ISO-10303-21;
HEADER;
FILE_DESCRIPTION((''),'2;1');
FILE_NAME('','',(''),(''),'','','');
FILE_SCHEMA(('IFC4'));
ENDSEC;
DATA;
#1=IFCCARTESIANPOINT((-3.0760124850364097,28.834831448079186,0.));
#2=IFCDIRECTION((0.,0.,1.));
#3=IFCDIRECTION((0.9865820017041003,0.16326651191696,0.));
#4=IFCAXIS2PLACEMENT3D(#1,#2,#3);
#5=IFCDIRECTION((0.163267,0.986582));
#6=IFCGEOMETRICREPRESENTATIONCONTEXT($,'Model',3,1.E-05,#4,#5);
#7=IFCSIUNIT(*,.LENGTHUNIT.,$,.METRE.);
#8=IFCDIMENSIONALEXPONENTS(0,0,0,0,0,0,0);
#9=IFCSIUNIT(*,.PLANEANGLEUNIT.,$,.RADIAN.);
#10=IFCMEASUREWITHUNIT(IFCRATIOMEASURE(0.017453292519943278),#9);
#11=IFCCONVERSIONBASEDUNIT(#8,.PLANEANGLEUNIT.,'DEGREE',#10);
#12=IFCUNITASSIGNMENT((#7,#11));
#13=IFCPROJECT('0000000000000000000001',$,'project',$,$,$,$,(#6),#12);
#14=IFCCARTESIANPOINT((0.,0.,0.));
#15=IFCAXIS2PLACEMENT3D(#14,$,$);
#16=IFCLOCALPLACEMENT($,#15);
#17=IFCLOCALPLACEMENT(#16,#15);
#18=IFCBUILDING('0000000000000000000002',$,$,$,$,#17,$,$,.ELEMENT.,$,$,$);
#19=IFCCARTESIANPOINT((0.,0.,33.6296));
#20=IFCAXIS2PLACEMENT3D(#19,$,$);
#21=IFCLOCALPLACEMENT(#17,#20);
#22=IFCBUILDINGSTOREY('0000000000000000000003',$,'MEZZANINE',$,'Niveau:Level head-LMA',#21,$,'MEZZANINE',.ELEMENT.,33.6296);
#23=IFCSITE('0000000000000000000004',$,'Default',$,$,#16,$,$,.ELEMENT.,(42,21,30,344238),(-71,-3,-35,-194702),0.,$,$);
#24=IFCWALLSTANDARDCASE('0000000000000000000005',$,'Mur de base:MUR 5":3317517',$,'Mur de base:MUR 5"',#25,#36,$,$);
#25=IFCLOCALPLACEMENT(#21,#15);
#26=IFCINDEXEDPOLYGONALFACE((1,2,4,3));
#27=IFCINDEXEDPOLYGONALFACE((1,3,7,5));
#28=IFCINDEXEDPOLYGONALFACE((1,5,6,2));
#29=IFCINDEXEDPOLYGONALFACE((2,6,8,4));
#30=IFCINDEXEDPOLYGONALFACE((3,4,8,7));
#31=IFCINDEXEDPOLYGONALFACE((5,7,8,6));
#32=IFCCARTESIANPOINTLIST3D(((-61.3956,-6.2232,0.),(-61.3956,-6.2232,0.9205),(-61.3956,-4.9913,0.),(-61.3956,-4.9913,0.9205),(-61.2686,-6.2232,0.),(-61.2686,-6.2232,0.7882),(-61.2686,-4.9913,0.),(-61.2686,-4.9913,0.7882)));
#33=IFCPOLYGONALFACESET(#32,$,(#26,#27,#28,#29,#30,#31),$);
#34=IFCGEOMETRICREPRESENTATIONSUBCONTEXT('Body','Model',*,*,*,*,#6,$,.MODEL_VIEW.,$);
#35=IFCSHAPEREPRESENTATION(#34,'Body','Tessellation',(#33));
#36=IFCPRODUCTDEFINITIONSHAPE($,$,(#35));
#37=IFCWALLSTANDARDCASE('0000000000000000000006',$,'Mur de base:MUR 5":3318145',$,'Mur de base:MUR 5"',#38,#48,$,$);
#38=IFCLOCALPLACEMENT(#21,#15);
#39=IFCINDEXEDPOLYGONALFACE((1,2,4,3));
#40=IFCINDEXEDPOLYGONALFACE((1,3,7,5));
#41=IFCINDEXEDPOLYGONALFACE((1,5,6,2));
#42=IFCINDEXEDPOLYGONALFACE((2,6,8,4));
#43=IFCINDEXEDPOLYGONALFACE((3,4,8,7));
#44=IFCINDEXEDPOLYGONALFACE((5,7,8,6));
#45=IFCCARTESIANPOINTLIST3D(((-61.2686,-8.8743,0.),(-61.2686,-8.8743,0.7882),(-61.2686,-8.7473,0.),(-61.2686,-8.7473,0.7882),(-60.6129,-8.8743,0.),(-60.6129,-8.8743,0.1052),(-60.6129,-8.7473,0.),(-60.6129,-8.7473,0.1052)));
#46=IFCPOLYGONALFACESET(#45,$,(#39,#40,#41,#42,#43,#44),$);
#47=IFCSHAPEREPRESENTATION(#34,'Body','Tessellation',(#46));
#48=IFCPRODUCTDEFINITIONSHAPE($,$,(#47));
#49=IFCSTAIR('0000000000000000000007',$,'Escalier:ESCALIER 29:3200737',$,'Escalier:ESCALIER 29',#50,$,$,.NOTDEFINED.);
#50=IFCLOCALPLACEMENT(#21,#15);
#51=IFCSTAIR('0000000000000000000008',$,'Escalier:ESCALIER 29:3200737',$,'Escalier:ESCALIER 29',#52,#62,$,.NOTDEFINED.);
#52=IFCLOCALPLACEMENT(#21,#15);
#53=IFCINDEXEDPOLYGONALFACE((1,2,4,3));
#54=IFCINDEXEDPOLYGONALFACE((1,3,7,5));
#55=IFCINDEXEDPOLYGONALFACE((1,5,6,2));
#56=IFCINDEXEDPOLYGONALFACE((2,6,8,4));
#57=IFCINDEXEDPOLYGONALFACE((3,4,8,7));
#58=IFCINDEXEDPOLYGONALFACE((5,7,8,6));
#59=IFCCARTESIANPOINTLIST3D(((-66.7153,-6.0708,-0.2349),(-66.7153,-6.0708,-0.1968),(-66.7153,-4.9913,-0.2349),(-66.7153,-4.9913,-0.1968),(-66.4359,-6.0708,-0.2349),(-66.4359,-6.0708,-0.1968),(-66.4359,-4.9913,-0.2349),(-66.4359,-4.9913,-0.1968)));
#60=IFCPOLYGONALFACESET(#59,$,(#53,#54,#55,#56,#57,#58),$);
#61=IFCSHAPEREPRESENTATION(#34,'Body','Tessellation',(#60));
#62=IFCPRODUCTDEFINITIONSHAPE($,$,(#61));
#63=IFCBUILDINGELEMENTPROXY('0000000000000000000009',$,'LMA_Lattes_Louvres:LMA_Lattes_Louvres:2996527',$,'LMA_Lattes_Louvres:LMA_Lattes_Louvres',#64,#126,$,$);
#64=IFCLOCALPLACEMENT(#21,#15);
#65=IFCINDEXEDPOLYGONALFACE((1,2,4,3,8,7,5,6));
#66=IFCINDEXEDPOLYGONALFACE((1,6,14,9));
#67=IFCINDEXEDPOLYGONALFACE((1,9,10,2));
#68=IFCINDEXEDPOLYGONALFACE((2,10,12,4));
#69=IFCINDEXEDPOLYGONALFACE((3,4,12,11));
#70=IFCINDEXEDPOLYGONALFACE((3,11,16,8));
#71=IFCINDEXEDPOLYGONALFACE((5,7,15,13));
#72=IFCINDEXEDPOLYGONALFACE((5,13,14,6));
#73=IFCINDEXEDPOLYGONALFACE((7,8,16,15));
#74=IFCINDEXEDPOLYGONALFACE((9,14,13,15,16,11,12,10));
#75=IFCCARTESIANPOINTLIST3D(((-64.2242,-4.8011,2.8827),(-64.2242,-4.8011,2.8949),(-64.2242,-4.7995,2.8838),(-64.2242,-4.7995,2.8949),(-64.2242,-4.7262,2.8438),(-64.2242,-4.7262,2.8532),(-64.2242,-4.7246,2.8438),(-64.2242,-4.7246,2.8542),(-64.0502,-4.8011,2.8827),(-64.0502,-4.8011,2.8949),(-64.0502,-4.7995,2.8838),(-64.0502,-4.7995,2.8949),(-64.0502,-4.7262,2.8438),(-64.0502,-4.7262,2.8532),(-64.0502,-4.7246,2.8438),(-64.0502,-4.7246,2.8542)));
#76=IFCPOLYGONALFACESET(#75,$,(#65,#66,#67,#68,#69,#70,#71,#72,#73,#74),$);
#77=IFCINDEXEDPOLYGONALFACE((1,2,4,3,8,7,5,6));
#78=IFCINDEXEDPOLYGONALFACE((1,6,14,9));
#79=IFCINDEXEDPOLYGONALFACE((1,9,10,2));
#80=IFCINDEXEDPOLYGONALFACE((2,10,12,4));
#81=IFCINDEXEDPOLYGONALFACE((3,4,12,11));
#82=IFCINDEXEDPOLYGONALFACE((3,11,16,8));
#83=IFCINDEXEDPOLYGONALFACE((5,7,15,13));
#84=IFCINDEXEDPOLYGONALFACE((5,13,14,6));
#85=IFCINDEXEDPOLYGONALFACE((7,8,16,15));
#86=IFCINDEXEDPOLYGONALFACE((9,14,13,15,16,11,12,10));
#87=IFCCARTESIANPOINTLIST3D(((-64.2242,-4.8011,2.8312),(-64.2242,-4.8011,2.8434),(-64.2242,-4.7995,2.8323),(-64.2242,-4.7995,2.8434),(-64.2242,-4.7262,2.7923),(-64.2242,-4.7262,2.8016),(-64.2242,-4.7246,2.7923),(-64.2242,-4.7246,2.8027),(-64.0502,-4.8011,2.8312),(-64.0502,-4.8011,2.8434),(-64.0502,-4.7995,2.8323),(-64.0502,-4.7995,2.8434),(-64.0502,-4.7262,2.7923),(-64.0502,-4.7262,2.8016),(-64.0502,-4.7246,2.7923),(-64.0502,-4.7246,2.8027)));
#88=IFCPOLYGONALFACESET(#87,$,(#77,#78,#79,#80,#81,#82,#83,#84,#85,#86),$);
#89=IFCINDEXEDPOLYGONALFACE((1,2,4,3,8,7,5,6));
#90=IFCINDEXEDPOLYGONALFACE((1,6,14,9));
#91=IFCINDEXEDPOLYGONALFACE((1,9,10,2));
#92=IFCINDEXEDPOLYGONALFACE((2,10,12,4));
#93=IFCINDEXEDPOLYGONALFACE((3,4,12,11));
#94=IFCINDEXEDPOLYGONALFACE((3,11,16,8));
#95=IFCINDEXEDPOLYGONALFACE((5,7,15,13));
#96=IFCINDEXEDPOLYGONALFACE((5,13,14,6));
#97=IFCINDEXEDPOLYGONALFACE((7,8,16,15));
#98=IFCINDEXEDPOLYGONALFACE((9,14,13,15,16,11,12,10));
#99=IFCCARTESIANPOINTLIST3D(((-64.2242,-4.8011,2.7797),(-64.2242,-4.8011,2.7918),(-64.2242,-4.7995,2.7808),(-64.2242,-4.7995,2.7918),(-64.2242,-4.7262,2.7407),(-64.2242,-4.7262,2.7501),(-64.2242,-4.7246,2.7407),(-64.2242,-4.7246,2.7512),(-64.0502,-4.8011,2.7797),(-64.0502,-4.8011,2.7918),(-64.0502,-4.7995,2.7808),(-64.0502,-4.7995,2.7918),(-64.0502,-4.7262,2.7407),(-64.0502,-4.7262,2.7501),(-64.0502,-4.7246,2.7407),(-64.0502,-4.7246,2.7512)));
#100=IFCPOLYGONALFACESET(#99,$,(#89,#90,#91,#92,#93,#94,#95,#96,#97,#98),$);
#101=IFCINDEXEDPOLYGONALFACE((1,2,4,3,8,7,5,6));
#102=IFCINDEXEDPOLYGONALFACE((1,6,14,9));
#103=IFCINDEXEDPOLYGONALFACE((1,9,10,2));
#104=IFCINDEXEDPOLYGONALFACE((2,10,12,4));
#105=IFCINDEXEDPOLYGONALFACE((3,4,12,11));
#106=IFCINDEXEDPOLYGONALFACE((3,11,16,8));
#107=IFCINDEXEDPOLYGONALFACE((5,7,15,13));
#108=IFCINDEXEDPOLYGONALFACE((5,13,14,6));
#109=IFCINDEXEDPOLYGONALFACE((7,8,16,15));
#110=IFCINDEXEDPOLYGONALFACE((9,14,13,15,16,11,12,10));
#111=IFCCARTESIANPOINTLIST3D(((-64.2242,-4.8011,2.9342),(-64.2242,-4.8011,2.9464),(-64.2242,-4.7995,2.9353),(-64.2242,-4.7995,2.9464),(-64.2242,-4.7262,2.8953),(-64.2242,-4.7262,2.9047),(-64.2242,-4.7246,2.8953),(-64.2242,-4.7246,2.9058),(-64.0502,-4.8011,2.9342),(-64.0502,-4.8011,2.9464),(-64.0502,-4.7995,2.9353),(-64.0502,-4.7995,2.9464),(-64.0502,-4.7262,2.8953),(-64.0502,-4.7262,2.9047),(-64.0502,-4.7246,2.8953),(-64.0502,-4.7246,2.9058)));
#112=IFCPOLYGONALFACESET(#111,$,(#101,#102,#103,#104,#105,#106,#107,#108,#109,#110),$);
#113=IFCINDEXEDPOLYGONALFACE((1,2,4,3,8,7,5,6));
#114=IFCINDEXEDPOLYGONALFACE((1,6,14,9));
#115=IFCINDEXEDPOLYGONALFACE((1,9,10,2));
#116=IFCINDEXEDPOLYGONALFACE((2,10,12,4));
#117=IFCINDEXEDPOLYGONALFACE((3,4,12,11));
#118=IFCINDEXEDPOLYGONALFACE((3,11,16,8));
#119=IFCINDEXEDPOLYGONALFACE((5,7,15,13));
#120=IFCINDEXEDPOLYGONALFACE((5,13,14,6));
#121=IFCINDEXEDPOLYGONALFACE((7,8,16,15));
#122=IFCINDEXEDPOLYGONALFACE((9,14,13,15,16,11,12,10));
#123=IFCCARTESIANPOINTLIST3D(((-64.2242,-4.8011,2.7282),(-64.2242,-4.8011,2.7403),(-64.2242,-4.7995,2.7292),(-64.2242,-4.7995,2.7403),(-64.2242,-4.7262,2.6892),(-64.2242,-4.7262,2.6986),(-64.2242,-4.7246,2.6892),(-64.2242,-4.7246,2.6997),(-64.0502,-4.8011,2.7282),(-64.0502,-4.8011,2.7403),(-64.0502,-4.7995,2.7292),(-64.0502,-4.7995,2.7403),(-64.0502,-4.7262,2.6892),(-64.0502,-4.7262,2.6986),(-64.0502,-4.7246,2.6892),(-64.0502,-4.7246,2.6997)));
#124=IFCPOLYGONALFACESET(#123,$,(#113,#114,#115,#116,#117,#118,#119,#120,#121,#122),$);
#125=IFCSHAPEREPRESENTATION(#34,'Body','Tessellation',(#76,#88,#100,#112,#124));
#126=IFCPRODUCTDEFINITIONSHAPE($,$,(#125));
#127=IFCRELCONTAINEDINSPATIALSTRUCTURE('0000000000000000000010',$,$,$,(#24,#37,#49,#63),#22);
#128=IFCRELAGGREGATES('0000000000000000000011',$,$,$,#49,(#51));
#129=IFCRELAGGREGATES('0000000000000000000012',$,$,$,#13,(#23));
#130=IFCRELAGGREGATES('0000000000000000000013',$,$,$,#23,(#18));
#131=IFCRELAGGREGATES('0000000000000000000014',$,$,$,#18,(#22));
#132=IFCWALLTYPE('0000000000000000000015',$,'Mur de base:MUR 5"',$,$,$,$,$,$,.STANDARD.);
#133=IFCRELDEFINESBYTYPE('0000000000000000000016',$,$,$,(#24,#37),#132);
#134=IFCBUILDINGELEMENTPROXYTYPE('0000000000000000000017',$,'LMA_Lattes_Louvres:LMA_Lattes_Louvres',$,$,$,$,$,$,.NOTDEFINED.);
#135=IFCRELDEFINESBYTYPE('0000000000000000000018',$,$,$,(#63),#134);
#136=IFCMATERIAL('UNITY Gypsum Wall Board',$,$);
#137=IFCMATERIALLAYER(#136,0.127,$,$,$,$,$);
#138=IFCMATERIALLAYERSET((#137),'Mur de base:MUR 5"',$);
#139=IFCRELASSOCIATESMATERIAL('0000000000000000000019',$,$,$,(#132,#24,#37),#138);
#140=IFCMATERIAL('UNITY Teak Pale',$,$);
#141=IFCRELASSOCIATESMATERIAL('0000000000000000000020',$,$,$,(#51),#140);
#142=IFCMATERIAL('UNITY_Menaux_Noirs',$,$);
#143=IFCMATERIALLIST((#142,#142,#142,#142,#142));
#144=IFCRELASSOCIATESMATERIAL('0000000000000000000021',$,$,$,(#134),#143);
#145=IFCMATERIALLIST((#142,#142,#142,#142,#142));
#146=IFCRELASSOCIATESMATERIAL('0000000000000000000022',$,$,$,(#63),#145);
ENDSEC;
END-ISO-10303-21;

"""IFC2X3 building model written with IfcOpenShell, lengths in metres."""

from ifc_helpers import new_model, entity, si_unit, converted_unit, direction, frame, frame_2d, origin, place, context, subcontext, project, spatial, polyline, rectangle, outline, extrude, clip, bounded_halfspace, source, transform, mapped, material, material_list, layer, layer_set, layer_usage, type_object, type_shapes, element, aggregate, save


model = new_model("IFC2X3")

# Units and contexts
model_context = context("Model", 3, precision=1e-05, world=frame((-3.0760124850364097, 28.834831448079186, 0.0), z_axis=(0.0, 0.0, 1.0), x_axis=(0.9865820017041003, 0.16326651191696, 0.0)), true_north=direction((0.163267, 0.986582)))
body_context = subcontext(model_context, "Body", "Model", "MODEL_VIEW")
ifc_project = project(units=[si_unit("LENGTHUNIT", "METRE"), converted_unit("PLANEANGLEUNIT", "DEGREE", entity("IfcRatioMeasure", 0.017453292519943278), si_unit("PLANEANGLEUNIT", "RADIAN"), dimensions=[0, 0, 0, 0, 0, 0, 0])], contexts=[model_context])

# Site, building, storey
site_placement = place(None, origin())
site = spatial("IfcSite", under=ifc_project, at=site_placement, Name="Default", CompositionType="ELEMENT", RefLatitude=(42, 21, 30, 344238), RefLongitude=(-71, -3, -35, -194702), RefElevation=0.0)
building_placement = place(site_placement, origin())
building = spatial("IfcBuilding", under=site, at=building_placement, CompositionType="ELEMENT")
storey_placement = place(building_placement, frame((0.0, 0.0, 33.6296)))
storey = spatial("IfcBuildingStorey", under=building, at=storey_placement, Name="MEZZANINE", ObjectType="Niveau:Level head-LMA", LongName="MEZZANINE", CompositionType="ELEMENT", Elevation=33.6296)

# Shared definitions
ifc_material_1 = material(Name="UNITY Gypsum Wall Board")
ifc_layer_1 = layer(ifc_material_1, 0.127)
ifc_layer_set_1 = layer_set([ifc_layer_1], Name="Mur de base:MUR 5\"")
wall_type_1 = type_object("IfcWallType", Name="Mur de base:MUR 5\"", PredefinedType="STANDARD", material=ifc_layer_set_1)

# Wall
ifc_layer_usage_1 = layer_usage(ifc_layer_set_1, "AXIS2", "NEGATIVE", 0.0635)
wall_1_placement = place(storey_placement, frame((-61.3321, -6.2232, 0.0), z_axis=(0.0, 0.0, 1.0), x_axis=(0.0, 1.0, 0.0)))
element("IfcWallStandardCase", 1, at=wall_1_placement, inside=storey, type_object=wall_type_1, material=ifc_layer_usage_1, Name="Mur de base:MUR 5\":3317517", ObjectType="Mur de base:MUR 5\"", context=body_context, shape_type="Clipping", body=[
    clip(extrude(rectangle(XDim=1.2319, YDim=0.127, at=frame_2d((0.6159, 0.0), x_axis=(-1.0, 0.0))), origin(), (0.0, 0.0, 1.0), 0.9205), bounded_halfspace(frame((0.0, -0.0635, 0.7882), z_axis=(0.0, -0.721387, 0.692532), x_axis=(1.0, 0.0, 0.0)), False, frame((0.0, -0.0635, 0.7882)), polyline([(0.0, 0.0), (1.2319, 0.0), (1.2319, 0.127), (0.0, 0.127), (0.0, 0.0)]))),
])

# Wall
ifc_layer_usage_2 = layer_usage(ifc_layer_set_1, "AXIS2", "NEGATIVE", 0.0635)
wall_2_placement = place(storey_placement, frame((-60.6129, -8.8108, 0.0), z_axis=(0.0, 0.0, 1.0), x_axis=(-1.0, 0.0, 0.0)))
element("IfcWallStandardCase", 2, at=wall_2_placement, inside=storey, type_object=wall_type_1, material=ifc_layer_usage_2, Name="Mur de base:MUR 5\":3318145", ObjectType="Mur de base:MUR 5\"", context=body_context, shape_type="Clipping", body=[
    clip(extrude(rectangle(XDim=0.6557, YDim=0.127, at=frame_2d((0.3279, 0.0), x_axis=(-1.0, 0.0))), origin(), (0.0, 0.0, 1.0), 0.7882), bounded_halfspace(frame((0.0, -0.0635, 0.1052), z_axis=(-0.721387, 0.0, 0.692532), x_axis=(0.0, -1.0, 0.0)), False, frame((0.0, -0.0635, 0.1052)), polyline([(0.0, 0.0), (0.6557, 0.0), (0.6557, 0.127), (0.0, 0.127), (0.0, 0.0)]))),
])

# Stairs
stair_1_placement = place(storey_placement, origin())
stair_1 = element("IfcStair", 3, at=stair_1_placement, inside=storey, Name="Escalier:ESCALIER 29:3200737", ObjectType="Escalier:ESCALIER 29", ShapeType="NOTDEFINED")
ifc_material_2 = material(Name="UNITY Teak Pale")
stair_2_placement = place(stair_1_placement, origin())
stair_2 = element("IfcStair", 4, at=stair_2_placement, material=ifc_material_2, Name="Escalier:ESCALIER 29:3200737", ObjectType="Escalier:ESCALIER 29", ShapeType="NOTDEFINED", context=body_context, shape_type="SweptSolid", body=[
    extrude(rectangle(XDim=0.2794, YDim=1.0795, at=frame_2d((0.0, 0.0), x_axis=(1.0, 0.0))), frame((-66.5756, -5.5311, -0.2349), z_axis=(0.0, 0.0, 1.0), x_axis=(-1.0, 0.0, 0.0)), (0.0, 0.0, 1.0), 0.0381),
])

aggregate(stair_1, [stair_2])

# Building element proxy
ifc_material_3 = material(Name="UNITY_Menaux_Noirs")
ifc_material_list_1 = material_list([ifc_material_3, ifc_material_3, ifc_material_3, ifc_material_3, ifc_material_3])
ifc_material_list_2 = material_list([ifc_material_3, ifc_material_3, ifc_material_3, ifc_material_3, ifc_material_3])
building_element_proxy_type = type_object("IfcBuildingElementProxyType", Name="LMA_Lattes_Louvres:LMA_Lattes_Louvres", PredefinedType="NOTDEFINED", material=ifc_material_list_2)
shared_shape_1 = source(origin(), body_context, "Body", "SweptSolid", [
    extrude(outline(polyline([(-0.0396, -0.0004), (0.041, -0.0004), (0.0448, 0.0093), (0.0433, 0.0099), (0.0399, 0.0012), (-0.0406, 0.0012), (-0.0451, -0.0101), (-0.0436, -0.0107), (-0.0396, -0.0004)])), frame((-0.087, -0.0382, 0.1797), z_axis=(1.0, 0.0, 0.0), x_axis=(0.0, -0.930221, -0.367)), (0.0, 0.0, 1.0), 0.174),
    extrude(outline(polyline([(-0.0396, -0.0004), (0.041, -0.0004), (0.0448, 0.0093), (0.0433, 0.0099), (0.0399, 0.0012), (-0.0406, 0.0012), (-0.0451, -0.0101), (-0.0436, -0.0107), (-0.0396, -0.0004)])), frame((-0.087, -0.0382, 0.1282), z_axis=(1.0, 0.0, 0.0), x_axis=(0.0, -0.930221, -0.367)), (0.0, 0.0, 1.0), 0.174),
    extrude(outline(polyline([(-0.0396, -0.0004), (0.041, -0.0004), (0.0448, 0.0093), (0.0433, 0.0099), (0.0399, 0.0012), (-0.0406, 0.0012), (-0.0451, -0.0101), (-0.0436, -0.0107), (-0.0396, -0.0004)])), frame((-0.087, -0.0382, 0.0766), z_axis=(1.0, 0.0, 0.0), x_axis=(0.0, -0.930221, -0.367)), (0.0, 0.0, 1.0), 0.174),
    extrude(outline(polyline([(-0.0396, -0.0004), (0.041, -0.0004), (0.0448, 0.0093), (0.0433, 0.0099), (0.0399, 0.0012), (-0.0406, 0.0012), (-0.0451, -0.0101), (-0.0436, -0.0107), (-0.0396, -0.0004)])), frame((-0.087, -0.0382, 0.2312), z_axis=(1.0, 0.0, 0.0), x_axis=(0.0, -0.930221, -0.367)), (0.0, 0.0, 1.0), 0.174),
    extrude(outline(polyline([(-0.0396, -0.0004), (0.041, -0.0004), (0.0448, 0.0093), (0.0433, 0.0099), (0.0399, 0.0012), (-0.0406, 0.0012), (-0.0451, -0.0101), (-0.0436, -0.0107), (-0.0396, -0.0004)])), frame((-0.087, -0.0382, 0.0251), z_axis=(1.0, 0.0, 0.0), x_axis=(0.0, -0.930221, -0.367)), (0.0, 0.0, 1.0), 0.174),
])
type_shapes(building_element_proxy_type, [shared_shape_1])
proxy_placement = place(storey_placement, frame((-64.1372, -4.8011, 2.6892), z_axis=(0.0, 0.0, 1.0), x_axis=(-1.0, 0.0, 0.0)))
element("IfcBuildingElementProxy", 5, at=proxy_placement, inside=storey, type_object=building_element_proxy_type, material=ifc_material_list_1, Name="LMA_Lattes_Louvres:LMA_Lattes_Louvres:2996527", ObjectType="LMA_Lattes_Louvres:LMA_Lattes_Louvres", context=body_context, shape_type="MappedRepresentation", body=[
    mapped(shared_shape_1, transform((0.0, 0.0, 0.0), scale=1.0)),
])

save(model, "model.ifc")
